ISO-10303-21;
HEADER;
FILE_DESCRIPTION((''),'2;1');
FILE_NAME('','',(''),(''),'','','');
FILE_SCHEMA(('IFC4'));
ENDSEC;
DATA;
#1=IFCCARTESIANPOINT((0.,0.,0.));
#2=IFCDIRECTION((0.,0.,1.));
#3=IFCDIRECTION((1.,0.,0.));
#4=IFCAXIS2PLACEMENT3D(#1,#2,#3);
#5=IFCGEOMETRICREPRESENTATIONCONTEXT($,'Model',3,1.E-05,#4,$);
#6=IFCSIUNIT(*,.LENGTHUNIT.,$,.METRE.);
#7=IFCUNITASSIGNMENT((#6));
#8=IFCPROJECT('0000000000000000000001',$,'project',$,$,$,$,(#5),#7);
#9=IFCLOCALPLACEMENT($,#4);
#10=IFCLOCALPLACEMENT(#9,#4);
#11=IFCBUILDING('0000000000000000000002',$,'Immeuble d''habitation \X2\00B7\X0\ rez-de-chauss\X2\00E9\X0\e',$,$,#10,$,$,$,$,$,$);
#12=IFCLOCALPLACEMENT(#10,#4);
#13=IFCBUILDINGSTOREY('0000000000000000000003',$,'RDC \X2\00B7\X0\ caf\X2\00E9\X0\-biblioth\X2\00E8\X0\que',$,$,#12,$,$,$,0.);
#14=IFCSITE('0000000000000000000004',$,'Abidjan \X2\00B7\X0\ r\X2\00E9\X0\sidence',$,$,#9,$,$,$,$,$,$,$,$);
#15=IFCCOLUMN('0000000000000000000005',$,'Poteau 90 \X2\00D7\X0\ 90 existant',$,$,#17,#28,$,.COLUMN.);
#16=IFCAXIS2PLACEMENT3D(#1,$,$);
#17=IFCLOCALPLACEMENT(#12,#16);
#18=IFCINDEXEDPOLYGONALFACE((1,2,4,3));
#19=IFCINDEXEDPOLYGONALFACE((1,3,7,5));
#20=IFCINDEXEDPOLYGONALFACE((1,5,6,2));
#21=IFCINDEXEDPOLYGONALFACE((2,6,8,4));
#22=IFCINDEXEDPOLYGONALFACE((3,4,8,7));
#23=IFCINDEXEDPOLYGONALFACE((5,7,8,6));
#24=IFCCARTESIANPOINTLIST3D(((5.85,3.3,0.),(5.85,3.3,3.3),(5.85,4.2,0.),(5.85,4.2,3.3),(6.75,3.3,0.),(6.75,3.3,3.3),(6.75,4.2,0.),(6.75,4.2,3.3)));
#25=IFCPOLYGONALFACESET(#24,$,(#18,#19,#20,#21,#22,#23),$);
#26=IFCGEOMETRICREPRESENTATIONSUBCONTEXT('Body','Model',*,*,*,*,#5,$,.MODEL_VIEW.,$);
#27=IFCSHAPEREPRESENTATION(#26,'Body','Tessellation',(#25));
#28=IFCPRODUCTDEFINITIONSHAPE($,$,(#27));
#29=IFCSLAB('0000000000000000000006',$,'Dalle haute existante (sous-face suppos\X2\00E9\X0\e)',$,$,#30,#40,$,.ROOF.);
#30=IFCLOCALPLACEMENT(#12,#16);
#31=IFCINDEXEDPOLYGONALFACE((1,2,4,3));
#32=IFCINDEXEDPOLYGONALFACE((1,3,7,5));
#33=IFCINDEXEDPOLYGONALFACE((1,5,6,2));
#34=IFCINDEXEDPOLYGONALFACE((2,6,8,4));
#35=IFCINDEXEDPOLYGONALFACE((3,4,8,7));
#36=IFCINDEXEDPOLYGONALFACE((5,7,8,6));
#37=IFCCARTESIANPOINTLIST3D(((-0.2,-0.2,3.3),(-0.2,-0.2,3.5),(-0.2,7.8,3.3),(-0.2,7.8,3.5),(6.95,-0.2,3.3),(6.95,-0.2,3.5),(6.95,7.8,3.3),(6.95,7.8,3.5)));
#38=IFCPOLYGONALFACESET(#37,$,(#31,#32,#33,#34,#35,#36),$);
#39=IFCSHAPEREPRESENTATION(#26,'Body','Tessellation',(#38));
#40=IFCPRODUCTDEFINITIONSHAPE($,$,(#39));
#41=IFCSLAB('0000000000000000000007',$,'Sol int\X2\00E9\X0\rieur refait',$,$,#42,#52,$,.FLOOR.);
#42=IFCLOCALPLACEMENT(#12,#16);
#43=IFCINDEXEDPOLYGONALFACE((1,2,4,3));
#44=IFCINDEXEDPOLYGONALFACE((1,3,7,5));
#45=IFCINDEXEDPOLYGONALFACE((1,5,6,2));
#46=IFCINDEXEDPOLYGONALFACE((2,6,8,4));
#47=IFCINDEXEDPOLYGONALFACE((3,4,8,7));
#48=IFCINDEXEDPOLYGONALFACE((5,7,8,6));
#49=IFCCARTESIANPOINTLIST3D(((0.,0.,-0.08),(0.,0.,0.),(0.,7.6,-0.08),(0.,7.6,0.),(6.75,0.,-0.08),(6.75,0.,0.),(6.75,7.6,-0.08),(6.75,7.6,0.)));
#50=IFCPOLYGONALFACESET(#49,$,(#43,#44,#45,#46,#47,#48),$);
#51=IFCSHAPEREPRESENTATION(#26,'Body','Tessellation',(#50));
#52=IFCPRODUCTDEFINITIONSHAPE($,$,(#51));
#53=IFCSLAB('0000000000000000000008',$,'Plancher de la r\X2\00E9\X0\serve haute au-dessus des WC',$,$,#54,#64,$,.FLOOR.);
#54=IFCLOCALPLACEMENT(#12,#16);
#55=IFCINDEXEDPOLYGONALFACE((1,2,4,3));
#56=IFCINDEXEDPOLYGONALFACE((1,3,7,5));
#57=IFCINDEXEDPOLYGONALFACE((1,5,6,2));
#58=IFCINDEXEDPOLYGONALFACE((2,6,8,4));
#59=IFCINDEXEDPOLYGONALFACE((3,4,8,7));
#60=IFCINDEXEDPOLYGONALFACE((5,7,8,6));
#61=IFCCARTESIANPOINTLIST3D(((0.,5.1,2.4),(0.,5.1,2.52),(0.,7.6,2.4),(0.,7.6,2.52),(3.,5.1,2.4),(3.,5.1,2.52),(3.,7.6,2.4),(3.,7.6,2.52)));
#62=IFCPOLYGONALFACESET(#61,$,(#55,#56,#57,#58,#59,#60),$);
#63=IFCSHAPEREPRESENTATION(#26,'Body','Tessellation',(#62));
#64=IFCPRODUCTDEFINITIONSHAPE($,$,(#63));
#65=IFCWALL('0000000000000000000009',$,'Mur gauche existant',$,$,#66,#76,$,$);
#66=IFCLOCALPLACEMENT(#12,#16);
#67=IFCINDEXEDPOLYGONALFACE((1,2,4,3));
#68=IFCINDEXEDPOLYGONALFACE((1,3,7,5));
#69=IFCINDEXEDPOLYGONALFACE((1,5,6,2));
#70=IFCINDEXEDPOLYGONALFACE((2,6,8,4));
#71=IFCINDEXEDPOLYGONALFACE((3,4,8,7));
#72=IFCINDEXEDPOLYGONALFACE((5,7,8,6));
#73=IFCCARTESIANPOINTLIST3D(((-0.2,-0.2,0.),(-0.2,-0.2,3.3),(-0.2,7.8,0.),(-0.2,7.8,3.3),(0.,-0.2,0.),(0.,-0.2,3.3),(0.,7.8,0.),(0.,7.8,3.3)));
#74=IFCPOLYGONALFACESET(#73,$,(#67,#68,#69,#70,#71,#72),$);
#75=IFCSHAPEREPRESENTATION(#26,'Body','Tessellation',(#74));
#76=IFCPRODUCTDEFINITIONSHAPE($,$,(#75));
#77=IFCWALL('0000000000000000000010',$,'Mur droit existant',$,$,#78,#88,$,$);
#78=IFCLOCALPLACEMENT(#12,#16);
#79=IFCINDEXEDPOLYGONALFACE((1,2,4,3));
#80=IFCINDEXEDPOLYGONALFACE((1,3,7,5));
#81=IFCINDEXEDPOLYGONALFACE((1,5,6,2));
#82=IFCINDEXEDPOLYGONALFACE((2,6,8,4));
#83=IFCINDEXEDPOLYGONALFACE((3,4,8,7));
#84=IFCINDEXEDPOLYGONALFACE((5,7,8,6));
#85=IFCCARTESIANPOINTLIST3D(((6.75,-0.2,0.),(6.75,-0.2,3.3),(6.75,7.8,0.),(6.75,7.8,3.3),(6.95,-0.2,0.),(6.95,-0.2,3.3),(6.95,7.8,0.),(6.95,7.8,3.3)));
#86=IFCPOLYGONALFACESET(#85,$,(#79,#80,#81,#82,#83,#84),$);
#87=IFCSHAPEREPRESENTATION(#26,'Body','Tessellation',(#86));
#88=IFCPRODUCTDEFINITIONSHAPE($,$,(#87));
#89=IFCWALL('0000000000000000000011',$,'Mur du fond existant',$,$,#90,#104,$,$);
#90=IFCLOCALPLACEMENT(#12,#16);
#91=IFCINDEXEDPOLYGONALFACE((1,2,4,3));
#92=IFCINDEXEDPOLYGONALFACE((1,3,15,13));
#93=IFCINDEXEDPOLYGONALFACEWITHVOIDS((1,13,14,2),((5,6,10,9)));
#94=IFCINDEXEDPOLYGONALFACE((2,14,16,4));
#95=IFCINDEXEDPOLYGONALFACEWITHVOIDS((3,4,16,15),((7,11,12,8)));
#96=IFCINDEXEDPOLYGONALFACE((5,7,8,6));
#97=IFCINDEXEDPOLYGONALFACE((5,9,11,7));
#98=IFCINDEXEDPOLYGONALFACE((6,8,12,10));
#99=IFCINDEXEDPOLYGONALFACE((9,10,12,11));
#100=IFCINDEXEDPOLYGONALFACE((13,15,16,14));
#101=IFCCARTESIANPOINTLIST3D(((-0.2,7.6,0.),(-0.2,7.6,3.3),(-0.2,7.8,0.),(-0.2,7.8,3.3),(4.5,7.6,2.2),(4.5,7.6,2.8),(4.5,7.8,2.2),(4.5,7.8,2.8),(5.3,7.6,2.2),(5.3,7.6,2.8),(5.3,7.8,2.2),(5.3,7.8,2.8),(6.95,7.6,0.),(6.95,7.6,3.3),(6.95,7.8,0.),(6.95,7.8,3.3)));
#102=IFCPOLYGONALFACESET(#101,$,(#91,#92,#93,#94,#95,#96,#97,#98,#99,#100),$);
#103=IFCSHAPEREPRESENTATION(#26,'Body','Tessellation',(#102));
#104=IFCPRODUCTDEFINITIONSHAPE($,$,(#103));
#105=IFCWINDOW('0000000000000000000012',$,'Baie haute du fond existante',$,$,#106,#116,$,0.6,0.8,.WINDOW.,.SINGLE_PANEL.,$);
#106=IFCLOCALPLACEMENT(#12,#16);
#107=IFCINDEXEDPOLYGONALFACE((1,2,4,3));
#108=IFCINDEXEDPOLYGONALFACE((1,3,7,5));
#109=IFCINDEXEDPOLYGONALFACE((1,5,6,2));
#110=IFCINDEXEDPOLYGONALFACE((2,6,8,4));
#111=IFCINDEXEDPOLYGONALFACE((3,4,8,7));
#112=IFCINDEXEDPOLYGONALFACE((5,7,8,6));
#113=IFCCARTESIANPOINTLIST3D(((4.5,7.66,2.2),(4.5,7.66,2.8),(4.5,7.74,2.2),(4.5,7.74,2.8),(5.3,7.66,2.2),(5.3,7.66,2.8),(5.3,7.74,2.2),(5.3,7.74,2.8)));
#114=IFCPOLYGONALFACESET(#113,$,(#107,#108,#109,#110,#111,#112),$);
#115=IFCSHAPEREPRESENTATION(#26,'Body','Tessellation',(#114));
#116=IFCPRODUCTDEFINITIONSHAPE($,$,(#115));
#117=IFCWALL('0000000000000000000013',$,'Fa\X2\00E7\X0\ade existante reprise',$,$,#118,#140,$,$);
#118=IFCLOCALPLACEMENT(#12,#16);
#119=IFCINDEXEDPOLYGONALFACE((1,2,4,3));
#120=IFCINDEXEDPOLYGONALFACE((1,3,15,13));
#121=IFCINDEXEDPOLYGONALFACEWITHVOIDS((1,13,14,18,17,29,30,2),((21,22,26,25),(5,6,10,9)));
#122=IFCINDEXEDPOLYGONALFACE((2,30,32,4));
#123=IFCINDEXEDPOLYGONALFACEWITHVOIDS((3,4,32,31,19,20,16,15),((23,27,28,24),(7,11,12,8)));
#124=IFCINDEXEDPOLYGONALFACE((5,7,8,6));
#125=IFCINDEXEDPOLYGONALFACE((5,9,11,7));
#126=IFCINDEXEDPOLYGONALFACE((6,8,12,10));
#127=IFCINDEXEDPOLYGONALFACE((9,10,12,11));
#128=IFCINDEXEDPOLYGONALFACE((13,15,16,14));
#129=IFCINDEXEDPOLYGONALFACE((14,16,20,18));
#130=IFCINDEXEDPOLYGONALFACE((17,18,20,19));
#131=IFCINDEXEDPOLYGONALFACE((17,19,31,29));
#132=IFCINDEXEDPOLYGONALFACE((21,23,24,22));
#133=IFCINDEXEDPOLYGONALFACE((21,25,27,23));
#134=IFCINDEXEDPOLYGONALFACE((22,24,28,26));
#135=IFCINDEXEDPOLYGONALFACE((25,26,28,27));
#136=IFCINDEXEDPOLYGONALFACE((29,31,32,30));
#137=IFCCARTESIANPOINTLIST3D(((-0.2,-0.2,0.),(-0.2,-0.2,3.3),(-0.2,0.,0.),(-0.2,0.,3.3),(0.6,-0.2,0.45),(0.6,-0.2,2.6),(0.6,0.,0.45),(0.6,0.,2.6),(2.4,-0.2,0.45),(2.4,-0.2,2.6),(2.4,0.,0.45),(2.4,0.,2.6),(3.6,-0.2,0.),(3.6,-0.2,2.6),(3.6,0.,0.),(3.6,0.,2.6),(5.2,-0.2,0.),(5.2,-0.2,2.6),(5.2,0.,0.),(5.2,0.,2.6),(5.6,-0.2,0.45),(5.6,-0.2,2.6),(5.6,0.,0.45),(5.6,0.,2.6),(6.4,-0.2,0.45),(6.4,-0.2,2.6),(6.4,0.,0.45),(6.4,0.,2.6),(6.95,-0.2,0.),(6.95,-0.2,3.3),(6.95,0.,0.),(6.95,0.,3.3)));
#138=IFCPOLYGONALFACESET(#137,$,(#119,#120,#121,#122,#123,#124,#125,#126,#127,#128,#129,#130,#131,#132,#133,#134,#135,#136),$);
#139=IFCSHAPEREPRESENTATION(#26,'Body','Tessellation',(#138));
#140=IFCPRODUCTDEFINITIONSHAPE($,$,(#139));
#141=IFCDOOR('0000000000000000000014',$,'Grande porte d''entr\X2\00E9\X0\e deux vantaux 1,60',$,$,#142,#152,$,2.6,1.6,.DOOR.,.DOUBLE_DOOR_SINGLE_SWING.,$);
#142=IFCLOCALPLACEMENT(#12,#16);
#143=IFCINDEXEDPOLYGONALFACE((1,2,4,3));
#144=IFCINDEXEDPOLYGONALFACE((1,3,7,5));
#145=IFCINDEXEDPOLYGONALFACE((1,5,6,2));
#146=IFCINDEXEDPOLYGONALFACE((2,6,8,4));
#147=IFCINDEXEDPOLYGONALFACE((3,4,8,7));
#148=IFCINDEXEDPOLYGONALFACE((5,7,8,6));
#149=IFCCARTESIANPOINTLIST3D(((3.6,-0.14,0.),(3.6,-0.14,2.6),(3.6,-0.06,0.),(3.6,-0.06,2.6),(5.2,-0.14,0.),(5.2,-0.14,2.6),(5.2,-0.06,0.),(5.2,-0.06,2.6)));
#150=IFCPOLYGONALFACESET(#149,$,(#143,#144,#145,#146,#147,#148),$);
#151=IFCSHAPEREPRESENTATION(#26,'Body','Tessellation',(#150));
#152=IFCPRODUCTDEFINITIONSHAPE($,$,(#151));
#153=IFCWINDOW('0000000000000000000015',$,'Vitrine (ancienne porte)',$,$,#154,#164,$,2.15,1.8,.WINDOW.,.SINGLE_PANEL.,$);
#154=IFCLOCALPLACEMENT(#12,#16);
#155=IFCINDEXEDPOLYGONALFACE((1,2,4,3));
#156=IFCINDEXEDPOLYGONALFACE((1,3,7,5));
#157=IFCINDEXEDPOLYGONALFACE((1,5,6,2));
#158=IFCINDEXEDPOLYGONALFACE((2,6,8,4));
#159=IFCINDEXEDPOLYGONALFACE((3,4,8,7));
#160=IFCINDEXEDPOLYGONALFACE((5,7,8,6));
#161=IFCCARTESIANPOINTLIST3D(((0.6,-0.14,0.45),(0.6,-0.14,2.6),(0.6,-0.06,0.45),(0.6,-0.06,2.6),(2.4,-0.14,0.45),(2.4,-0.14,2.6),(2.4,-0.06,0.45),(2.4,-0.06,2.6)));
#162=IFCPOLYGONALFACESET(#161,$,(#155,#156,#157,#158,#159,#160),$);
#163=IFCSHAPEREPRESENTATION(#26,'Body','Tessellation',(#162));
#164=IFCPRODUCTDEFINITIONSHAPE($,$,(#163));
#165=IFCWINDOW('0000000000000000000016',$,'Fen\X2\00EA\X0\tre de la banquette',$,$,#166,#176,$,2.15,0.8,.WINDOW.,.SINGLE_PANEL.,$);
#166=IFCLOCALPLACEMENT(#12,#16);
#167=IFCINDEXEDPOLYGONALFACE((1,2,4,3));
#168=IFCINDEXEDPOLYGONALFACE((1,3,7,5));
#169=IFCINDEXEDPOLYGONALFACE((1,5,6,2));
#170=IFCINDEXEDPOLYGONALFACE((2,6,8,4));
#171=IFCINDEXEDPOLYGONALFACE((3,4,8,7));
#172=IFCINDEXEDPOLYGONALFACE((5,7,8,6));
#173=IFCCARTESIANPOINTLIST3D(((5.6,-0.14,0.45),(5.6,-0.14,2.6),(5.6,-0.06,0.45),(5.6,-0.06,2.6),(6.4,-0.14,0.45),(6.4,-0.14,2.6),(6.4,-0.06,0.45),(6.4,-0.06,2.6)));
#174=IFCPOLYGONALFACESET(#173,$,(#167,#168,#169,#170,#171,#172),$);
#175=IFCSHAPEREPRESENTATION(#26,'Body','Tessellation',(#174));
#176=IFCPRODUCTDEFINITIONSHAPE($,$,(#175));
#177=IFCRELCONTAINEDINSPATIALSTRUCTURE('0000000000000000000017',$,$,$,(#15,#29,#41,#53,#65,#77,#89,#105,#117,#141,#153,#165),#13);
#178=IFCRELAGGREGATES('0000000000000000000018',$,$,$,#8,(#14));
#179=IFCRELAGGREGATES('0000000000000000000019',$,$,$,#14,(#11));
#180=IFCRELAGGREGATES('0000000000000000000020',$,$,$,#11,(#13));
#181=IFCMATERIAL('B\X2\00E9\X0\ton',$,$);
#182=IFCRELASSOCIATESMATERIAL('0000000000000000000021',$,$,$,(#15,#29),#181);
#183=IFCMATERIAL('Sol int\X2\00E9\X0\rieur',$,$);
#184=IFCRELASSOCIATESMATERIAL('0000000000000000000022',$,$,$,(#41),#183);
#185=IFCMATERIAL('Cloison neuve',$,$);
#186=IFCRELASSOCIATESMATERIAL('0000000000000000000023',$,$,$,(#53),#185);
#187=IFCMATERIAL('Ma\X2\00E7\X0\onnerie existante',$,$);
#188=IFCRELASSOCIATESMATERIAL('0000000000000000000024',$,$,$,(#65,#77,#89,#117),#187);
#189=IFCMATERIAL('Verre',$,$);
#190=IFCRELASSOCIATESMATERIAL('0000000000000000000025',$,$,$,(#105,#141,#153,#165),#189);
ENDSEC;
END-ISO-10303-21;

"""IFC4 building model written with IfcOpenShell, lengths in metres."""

from ifc_helpers import new_model, si_unit, frame, frame_2d, origin, origin_with_axes, place, context, subcontext, project, spatial, rectangle, extrude, material, element, fill, save


model = new_model("IFC4")

# Units and contexts
model_context = context("Model", 3, precision=1e-05, world=origin_with_axes())
body_context = subcontext(model_context, "Body", "Model", "MODEL_VIEW")
ifc_project = project(units=[si_unit("LENGTHUNIT", "METRE")], contexts=[model_context])

# Site, building, storey
site_placement = place(None, origin_with_axes())
site = spatial("IfcSite", under=ifc_project, at=site_placement, Name="Abidjan · résidence")
building_placement = place(site_placement, origin_with_axes())
building = spatial("IfcBuilding", under=site, at=building_placement, Name="Immeuble d'habitation · rez-de-chaussée")
storey_placement = place(building_placement, origin_with_axes())
storey = spatial("IfcBuildingStorey", under=building, at=storey_placement, Name="RDC · café-bibliothèque", Elevation=0.0)

# Column
ifc_material_1 = material(Name="Béton")
column_placement = place(storey_placement, origin_with_axes())
element("IfcColumn", 1, at=column_placement, inside=storey, material=ifc_material_1, Name="Poteau 90 × 90 existant", PredefinedType="COLUMN", context=body_context, shape_type="SweptSolid", body=[
    extrude(rectangle(XDim=0.9, YDim=0.9, at=frame_2d((6.3, 3.75))), origin(), (0.0, 0.0, 1.0), 3.3),
])

# Slabs
slab_1_placement = place(storey_placement, origin_with_axes())
element("IfcSlab", 2, at=slab_1_placement, inside=storey, material=ifc_material_1, Name="Dalle haute existante (sous-face supposée)", PredefinedType="ROOF", context=body_context, shape_type="SweptSolid", body=[
    extrude(rectangle(XDim=7.15, YDim=8.0, at=frame_2d((3.375, 3.8))), frame((0.0, 0.0, 3.3)), (0.0, 0.0, 1.0), 0.2),
])
ifc_material_2 = material(Name="Sol intérieur")
slab_2_placement = place(storey_placement, origin_with_axes())
element("IfcSlab", 3, at=slab_2_placement, inside=storey, material=ifc_material_2, Name="Sol intérieur refait", PredefinedType="FLOOR", context=body_context, shape_type="SweptSolid", body=[
    extrude(rectangle(XDim=6.75, YDim=7.6, at=frame_2d((3.375, 3.8))), frame((0.0, 0.0, -0.08)), (0.0, 0.0, 1.0), 0.08),
])
ifc_material_3 = material(Name="Cloison neuve")
slab_3_placement = place(storey_placement, origin_with_axes())
element("IfcSlab", 4, at=slab_3_placement, inside=storey, material=ifc_material_3, Name="Plancher de la réserve haute au-dessus des WC", PredefinedType="FLOOR", context=body_context, shape_type="SweptSolid", body=[
    extrude(rectangle(XDim=3.0, YDim=2.5, at=frame_2d((1.5, 6.35))), frame((0.0, 0.0, 2.4)), (0.0, 0.0, 1.0), 0.12),
])

# Walls
ifc_material_4 = material(Name="Maçonnerie existante")
wall_1_placement = place(storey_placement, origin_with_axes())
element("IfcWall", 5, at=wall_1_placement, inside=storey, material=ifc_material_4, Name="Mur gauche existant", context=body_context, shape_type="SweptSolid", body=[
    extrude(rectangle(XDim=0.2, YDim=8.0, at=frame_2d((-0.1, 3.8))), origin(), (0.0, 0.0, 1.0), 3.3),
])
wall_2_placement = place(storey_placement, origin_with_axes())
element("IfcWall", 6, at=wall_2_placement, inside=storey, material=ifc_material_4, Name="Mur droit existant", context=body_context, shape_type="SweptSolid", body=[
    extrude(rectangle(XDim=0.2, YDim=8.0, at=frame_2d((6.85, 3.8))), origin(), (0.0, 0.0, 1.0), 3.3),
])

# Wall, opening, window
wall_3_placement = place(storey_placement, origin_with_axes())
wall_3 = element("IfcWall", 7, at=wall_3_placement, inside=storey, material=ifc_material_4, Name="Mur du fond existant", context=body_context, shape_type="SweptSolid", body=[
    extrude(rectangle(XDim=7.15, YDim=0.2, at=frame_2d((3.375, 7.7))), origin(), (0.0, 0.0, 1.0), 3.3),
])
opening_1_placement = place(wall_3_placement, origin_with_axes())
opening_1 = element("IfcOpeningElement", 8, at=opening_1_placement, cuts=wall_3, context=body_context, shape_type="SweptSolid", body=[
    extrude(rectangle(XDim=0.8, YDim=0.3, at=frame_2d((4.9, 7.7))), frame((0.0, 0.0, 2.2)), (0.0, 0.0, 1.0), 0.6),
])
ifc_material_5 = material(Name="Verre")
window_1_placement = place(storey_placement, origin_with_axes())
window_1 = element("IfcWindow", 9, at=window_1_placement, inside=storey, material=ifc_material_5, Name="Baie haute du fond existante", OverallHeight=0.6, OverallWidth=0.8, PartitioningType="SINGLE_PANEL", PredefinedType="WINDOW", context=body_context, shape_type="SweptSolid", body=[
    extrude(rectangle(XDim=0.8, YDim=0.08, at=frame_2d((4.9, 7.7))), frame((0.0, 0.0, 2.2)), (0.0, 0.0, 1.0), 0.6),
])
fill(opening_1, window_1)

# Wall, openings, door, windows
wall_4_placement = place(storey_placement, origin_with_axes())
wall_4 = element("IfcWall", 10, at=wall_4_placement, inside=storey, material=ifc_material_4, Name="Façade existante reprise", context=body_context, shape_type="SweptSolid", body=[
    extrude(rectangle(XDim=7.15, YDim=0.2, at=frame_2d((3.375, -0.1))), origin(), (0.0, 0.0, 1.0), 3.3),
])
opening_2_placement = place(wall_4_placement, origin_with_axes())
opening_2 = element("IfcOpeningElement", 11, at=opening_2_placement, cuts=wall_4, context=body_context, shape_type="SweptSolid", body=[
    extrude(rectangle(XDim=1.6, YDim=0.3, at=frame_2d((4.4, -0.1))), origin(), (0.0, 0.0, 1.0), 2.6),
])
opening_3_placement = place(wall_4_placement, origin_with_axes())
opening_3 = element("IfcOpeningElement", 12, at=opening_3_placement, cuts=wall_4, context=body_context, shape_type="SweptSolid", body=[
    extrude(rectangle(XDim=1.8, YDim=0.3, at=frame_2d((1.5, -0.1))), frame((0.0, 0.0, 0.45)), (0.0, 0.0, 1.0), 2.15),
])
opening_4_placement = place(wall_4_placement, origin_with_axes())
opening_4 = element("IfcOpeningElement", 13, at=opening_4_placement, cuts=wall_4, context=body_context, shape_type="SweptSolid", body=[
    extrude(rectangle(XDim=0.8, YDim=0.3, at=frame_2d((6.0, -0.1))), frame((0.0, 0.0, 0.45)), (0.0, 0.0, 1.0), 2.15),
])
door_1_placement = place(storey_placement, origin_with_axes())
door_1 = element("IfcDoor", 14, at=door_1_placement, inside=storey, material=ifc_material_5, Name="Grande porte d'entrée deux vantaux 1,60", OperationType="DOUBLE_DOOR_SINGLE_SWING", OverallHeight=2.6, OverallWidth=1.6, PredefinedType="DOOR", context=body_context, shape_type="SweptSolid", body=[
    extrude(rectangle(XDim=1.6, YDim=0.08, at=frame_2d((4.4, -0.1))), origin(), (0.0, 0.0, 1.0), 2.6),
])
fill(opening_2, door_1)
window_2_placement = place(storey_placement, origin_with_axes())
window_2 = element("IfcWindow", 15, at=window_2_placement, inside=storey, material=ifc_material_5, Name="Vitrine (ancienne porte)", OverallHeight=2.15, OverallWidth=1.8, PartitioningType="SINGLE_PANEL", PredefinedType="WINDOW", context=body_context, shape_type="SweptSolid", body=[
    extrude(rectangle(XDim=1.8, YDim=0.08, at=frame_2d((1.5, -0.1))), frame((0.0, 0.0, 0.45)), (0.0, 0.0, 1.0), 2.15),
])
fill(opening_3, window_2)
window_3_placement = place(storey_placement, origin_with_axes())
window_3 = element("IfcWindow", 16, at=window_3_placement, inside=storey, material=ifc_material_5, Name="Fenêtre de la banquette", OverallHeight=2.15, OverallWidth=0.8, PartitioningType="SINGLE_PANEL", PredefinedType="WINDOW", context=body_context, shape_type="SweptSolid", body=[
    extrude(rectangle(XDim=0.8, YDim=0.08, at=frame_2d((6.0, -0.1))), frame((0.0, 0.0, 0.45)), (0.0, 0.0, 1.0), 2.15),
])
fill(opening_4, window_3)

save(model, "model.ifc")
